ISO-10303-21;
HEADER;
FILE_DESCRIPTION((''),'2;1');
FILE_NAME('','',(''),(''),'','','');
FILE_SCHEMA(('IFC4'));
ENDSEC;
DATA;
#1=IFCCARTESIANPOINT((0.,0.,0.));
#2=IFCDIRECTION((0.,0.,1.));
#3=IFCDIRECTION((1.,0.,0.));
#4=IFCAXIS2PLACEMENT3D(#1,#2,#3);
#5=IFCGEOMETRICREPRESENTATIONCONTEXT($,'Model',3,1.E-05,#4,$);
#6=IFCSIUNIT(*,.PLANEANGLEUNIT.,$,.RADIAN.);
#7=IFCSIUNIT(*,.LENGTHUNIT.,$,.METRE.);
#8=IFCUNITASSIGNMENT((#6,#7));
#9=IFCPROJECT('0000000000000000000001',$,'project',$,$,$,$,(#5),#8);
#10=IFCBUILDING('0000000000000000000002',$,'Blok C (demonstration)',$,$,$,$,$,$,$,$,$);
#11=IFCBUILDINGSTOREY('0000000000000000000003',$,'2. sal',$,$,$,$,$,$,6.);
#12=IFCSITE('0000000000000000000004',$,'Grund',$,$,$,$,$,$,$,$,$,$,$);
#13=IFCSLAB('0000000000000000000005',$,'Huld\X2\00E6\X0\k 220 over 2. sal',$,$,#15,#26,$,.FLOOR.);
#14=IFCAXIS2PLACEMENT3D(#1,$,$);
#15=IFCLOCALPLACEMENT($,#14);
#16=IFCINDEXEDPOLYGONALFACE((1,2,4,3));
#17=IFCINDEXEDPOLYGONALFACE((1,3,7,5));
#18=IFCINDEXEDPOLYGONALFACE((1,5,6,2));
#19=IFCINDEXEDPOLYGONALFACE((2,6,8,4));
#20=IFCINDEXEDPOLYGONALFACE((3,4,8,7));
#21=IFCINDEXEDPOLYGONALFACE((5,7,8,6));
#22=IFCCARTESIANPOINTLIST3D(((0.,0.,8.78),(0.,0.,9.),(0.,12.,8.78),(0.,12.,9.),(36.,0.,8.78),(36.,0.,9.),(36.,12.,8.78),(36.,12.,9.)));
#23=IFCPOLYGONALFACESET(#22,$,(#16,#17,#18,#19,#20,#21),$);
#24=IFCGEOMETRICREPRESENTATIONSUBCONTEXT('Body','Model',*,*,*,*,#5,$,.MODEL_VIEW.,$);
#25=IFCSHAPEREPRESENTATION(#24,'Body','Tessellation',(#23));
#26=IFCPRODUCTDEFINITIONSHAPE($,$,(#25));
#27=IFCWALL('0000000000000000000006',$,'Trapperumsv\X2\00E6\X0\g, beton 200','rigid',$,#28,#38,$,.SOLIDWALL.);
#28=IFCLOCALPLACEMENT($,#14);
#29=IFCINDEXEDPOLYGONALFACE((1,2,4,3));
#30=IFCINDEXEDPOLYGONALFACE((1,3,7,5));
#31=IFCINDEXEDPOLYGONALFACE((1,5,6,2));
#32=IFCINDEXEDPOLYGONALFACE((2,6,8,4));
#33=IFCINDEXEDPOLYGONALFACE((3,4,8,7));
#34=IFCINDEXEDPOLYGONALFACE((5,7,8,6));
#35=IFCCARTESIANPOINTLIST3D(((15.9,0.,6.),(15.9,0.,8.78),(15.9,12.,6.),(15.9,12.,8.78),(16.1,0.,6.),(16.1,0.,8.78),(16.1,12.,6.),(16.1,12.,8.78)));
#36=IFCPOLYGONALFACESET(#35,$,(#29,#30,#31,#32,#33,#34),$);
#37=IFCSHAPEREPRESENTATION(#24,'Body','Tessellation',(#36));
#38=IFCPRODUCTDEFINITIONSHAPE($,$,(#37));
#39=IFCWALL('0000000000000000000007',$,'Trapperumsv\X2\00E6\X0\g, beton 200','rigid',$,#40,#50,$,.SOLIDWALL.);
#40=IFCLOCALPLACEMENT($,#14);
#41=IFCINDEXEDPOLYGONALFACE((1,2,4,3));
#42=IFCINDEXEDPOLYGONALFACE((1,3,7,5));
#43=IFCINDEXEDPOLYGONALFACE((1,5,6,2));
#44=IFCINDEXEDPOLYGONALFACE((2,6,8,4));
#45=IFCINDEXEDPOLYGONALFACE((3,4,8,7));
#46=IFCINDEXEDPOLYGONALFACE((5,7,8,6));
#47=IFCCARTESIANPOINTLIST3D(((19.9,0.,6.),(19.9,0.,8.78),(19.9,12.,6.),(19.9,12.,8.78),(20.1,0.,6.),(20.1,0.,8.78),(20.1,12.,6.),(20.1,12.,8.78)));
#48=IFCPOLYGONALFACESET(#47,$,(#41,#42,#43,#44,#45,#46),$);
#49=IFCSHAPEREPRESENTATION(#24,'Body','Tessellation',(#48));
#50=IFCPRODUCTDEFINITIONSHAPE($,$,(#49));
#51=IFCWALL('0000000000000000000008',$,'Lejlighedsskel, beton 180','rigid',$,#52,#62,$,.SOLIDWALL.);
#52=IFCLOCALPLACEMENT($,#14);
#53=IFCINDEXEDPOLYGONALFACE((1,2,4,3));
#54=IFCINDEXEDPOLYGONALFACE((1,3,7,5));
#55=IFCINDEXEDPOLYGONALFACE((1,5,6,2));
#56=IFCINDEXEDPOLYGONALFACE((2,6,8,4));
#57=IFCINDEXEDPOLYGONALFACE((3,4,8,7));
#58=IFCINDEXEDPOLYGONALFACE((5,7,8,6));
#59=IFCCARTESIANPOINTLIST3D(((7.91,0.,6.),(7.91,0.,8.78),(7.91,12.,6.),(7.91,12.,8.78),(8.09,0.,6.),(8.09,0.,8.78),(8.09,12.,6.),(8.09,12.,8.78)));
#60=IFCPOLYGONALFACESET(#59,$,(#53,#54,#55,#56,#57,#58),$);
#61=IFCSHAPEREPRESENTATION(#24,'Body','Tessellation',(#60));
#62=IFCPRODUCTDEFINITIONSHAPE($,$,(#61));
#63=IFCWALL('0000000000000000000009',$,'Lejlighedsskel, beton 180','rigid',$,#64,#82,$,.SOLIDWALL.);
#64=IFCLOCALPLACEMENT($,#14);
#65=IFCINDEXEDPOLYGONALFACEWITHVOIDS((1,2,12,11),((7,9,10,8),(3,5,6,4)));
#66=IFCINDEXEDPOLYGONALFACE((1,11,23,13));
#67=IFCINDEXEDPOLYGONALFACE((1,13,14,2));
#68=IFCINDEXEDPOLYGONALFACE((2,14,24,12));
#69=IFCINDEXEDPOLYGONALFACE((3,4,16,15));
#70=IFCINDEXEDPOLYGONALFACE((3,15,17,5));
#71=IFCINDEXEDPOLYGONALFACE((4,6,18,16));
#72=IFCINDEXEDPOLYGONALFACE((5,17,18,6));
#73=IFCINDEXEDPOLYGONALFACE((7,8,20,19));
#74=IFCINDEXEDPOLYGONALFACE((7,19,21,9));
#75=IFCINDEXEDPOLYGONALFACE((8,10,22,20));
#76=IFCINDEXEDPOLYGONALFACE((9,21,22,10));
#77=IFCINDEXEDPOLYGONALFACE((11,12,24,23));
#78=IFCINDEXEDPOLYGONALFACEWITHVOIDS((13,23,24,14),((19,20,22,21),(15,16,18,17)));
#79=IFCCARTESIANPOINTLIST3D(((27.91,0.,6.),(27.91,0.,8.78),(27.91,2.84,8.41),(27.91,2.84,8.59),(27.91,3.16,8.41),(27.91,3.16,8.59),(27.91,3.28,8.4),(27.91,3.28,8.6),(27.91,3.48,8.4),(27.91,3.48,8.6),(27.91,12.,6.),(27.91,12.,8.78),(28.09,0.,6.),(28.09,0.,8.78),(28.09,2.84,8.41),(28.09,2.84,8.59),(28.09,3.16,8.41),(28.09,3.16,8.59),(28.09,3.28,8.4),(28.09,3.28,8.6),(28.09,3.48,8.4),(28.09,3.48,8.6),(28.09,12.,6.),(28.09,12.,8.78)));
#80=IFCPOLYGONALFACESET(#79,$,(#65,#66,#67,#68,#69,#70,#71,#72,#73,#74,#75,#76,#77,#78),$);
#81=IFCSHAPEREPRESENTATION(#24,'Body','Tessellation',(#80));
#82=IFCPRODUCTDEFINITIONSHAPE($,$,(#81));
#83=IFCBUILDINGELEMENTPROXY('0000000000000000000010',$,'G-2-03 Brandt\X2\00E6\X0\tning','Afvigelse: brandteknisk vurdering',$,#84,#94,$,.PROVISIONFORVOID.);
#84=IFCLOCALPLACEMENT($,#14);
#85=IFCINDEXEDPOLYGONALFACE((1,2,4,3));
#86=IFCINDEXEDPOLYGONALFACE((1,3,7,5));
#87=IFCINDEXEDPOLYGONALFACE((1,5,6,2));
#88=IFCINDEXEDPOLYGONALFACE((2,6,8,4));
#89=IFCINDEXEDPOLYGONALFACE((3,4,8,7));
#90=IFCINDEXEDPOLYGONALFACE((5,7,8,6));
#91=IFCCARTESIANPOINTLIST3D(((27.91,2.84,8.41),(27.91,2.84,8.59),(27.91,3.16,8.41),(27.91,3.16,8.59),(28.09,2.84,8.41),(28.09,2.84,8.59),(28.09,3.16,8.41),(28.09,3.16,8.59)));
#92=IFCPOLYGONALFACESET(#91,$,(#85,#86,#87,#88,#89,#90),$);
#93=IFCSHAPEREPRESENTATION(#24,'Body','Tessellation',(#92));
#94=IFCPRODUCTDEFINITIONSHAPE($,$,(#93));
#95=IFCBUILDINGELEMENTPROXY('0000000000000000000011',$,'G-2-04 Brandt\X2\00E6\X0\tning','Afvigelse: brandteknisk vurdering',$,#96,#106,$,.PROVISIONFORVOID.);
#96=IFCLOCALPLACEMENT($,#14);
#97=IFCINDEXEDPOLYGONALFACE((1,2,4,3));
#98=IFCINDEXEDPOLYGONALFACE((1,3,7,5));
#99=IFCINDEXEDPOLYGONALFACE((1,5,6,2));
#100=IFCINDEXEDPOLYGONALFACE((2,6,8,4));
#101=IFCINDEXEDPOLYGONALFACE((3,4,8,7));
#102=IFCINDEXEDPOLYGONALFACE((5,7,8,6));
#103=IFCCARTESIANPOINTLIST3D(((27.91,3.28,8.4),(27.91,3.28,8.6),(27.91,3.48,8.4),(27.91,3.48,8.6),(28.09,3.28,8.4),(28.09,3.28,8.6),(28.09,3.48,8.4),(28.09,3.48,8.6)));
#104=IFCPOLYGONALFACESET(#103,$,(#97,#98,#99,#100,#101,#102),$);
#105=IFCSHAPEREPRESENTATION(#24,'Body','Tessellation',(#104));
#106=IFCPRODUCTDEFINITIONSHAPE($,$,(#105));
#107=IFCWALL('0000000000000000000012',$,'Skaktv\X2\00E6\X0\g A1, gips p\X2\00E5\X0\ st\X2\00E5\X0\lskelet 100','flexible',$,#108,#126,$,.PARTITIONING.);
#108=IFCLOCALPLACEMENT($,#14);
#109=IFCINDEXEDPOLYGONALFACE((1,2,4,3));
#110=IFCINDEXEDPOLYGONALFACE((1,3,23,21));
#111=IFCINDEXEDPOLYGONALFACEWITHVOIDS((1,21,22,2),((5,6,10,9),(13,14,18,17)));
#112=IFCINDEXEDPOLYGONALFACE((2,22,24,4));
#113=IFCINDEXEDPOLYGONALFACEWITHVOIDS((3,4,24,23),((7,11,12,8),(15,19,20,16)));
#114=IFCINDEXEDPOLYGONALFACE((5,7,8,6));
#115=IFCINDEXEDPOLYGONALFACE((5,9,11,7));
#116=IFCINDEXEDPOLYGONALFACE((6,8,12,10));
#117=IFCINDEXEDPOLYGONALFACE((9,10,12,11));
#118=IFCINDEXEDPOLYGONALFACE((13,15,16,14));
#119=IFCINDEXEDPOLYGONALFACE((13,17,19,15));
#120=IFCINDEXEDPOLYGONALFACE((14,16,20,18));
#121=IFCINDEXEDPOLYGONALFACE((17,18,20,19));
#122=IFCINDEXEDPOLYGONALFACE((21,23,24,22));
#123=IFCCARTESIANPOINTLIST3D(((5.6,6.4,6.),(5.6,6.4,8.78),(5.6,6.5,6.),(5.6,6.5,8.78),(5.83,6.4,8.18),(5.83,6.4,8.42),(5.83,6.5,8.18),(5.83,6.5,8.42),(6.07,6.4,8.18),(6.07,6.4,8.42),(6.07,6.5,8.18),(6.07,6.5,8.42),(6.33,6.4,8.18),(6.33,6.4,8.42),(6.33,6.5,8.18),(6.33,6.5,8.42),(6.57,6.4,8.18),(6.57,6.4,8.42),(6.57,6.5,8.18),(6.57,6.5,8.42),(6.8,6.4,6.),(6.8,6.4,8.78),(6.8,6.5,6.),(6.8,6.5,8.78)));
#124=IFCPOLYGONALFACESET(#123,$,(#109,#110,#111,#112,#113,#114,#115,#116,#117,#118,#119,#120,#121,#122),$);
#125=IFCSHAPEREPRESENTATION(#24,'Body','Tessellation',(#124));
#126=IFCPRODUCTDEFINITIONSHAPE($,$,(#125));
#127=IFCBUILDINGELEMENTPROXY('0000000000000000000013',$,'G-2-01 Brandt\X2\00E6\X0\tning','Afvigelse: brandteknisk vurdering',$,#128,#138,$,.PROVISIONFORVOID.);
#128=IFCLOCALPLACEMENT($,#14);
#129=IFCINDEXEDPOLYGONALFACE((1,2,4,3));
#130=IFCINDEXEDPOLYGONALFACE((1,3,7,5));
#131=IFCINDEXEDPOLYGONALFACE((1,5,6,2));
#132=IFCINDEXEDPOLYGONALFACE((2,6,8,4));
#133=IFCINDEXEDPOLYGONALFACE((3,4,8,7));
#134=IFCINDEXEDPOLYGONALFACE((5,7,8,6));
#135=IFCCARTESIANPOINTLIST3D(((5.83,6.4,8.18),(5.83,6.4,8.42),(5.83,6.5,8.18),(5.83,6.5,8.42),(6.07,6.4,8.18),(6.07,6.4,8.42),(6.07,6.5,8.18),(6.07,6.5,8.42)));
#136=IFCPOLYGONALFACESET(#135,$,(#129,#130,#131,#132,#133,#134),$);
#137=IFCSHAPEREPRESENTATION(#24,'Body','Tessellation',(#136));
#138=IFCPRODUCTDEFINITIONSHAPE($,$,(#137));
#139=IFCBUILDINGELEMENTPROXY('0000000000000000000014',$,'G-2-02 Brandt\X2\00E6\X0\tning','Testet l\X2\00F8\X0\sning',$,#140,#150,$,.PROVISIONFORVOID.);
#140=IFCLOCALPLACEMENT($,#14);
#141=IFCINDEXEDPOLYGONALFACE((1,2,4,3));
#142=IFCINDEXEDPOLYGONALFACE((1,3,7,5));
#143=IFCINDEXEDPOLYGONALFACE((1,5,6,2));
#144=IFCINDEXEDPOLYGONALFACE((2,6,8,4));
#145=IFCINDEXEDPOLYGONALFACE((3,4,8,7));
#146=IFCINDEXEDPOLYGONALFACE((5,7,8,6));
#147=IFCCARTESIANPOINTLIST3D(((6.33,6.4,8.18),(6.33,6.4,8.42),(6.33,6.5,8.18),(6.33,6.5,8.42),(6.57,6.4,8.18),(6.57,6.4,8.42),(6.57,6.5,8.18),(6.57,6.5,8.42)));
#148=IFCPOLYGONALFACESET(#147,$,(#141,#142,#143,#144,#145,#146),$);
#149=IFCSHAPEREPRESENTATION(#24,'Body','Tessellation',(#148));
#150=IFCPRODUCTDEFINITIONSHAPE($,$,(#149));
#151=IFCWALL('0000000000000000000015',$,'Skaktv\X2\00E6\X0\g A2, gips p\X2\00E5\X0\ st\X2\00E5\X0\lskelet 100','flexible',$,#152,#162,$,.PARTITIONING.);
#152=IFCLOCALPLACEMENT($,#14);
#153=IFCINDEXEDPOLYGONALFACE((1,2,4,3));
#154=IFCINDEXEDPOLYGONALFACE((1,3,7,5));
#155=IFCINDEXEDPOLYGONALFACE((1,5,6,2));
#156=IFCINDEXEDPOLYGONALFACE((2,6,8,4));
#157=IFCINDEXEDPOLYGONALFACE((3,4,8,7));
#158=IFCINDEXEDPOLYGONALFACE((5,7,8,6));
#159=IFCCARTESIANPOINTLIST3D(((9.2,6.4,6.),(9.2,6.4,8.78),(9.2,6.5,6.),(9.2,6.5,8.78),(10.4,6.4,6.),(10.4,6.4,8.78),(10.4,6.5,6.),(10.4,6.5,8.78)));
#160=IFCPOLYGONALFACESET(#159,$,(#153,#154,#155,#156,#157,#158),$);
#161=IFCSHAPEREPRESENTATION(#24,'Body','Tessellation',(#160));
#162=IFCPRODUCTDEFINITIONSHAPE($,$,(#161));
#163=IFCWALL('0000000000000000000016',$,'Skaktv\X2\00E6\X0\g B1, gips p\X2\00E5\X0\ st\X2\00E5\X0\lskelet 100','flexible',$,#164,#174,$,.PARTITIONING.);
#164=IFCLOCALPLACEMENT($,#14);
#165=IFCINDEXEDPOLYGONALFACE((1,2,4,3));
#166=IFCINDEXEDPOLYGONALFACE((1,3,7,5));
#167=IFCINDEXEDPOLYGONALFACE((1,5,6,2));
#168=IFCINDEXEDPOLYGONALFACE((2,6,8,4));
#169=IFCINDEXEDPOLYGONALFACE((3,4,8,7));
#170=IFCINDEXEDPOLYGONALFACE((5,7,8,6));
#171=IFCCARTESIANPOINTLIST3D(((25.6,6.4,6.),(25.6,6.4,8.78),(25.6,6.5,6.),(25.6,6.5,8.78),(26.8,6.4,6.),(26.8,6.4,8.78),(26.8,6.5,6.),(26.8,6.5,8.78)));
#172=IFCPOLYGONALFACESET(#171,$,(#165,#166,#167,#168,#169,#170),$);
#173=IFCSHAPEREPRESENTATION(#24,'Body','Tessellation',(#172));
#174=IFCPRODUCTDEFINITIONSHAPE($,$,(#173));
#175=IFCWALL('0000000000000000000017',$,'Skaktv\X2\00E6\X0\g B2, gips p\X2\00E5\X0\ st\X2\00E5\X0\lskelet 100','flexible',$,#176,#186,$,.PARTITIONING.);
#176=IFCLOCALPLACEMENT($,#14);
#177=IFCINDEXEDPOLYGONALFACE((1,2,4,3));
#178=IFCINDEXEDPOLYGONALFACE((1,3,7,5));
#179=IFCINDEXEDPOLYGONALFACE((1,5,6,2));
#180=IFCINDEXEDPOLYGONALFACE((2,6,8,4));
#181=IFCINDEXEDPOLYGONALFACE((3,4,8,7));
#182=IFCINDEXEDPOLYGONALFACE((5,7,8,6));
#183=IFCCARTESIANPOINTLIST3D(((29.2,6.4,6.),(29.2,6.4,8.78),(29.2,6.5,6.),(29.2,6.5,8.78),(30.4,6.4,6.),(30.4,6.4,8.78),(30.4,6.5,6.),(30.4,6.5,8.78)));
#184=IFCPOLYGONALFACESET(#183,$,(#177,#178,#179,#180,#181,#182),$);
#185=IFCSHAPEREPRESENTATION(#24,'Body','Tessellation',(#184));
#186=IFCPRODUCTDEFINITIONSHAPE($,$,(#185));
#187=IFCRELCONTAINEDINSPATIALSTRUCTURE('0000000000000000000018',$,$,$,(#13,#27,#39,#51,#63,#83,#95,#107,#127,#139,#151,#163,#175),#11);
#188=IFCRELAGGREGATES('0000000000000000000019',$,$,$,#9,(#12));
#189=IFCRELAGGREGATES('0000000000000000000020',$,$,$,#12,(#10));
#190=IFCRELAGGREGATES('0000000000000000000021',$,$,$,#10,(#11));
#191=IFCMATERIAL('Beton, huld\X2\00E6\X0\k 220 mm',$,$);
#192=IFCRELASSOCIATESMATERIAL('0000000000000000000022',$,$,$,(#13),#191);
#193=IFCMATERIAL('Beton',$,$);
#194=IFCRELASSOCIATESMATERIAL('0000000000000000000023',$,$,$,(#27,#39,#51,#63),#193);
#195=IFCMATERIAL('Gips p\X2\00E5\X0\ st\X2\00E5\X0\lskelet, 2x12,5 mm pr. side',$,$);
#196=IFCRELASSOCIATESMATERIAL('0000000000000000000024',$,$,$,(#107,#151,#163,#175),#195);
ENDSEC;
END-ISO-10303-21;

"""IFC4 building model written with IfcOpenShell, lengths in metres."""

from ifc_helpers import new_model, si_unit, frame, origin_with_axes, place, context, subcontext, project, spatial, polyline, outline, extrude, material, element, fill, save


model = new_model("IFC4")

# Units and contexts
model_context = context("Model", 3, precision=1e-05, world=origin_with_axes())
body_context = subcontext(model_context, "Body", "Model", "MODEL_VIEW")
ifc_project = project(units=[si_unit("PLANEANGLEUNIT", "RADIAN"), si_unit("LENGTHUNIT", "METRE")], contexts=[model_context])

# Site, building, storey
site = spatial("IfcSite", under=ifc_project, Name="Grund")
building = spatial("IfcBuilding", under=site, Name="Blok C (demonstration)")
storey = spatial("IfcBuildingStorey", under=building, Name="2. sal", Elevation=6.0)

# Slab
ifc_material_1 = material(Name="Beton, huldæk 220 mm")
slab_placement = place(None, origin_with_axes())
element("IfcSlab", 1, at=slab_placement, inside=storey, material=ifc_material_1, Name="Huldæk 220 over 2. sal", PredefinedType="FLOOR", context=body_context, shape_type="SweptSolid", body=[
    extrude(outline(polyline([(0.0, 0.0), (36.0, 0.0), (36.0, 12.0), (0.0, 12.0), (0.0, 0.0)])), frame((0.0, 0.0, 8.78)), (0.0, 0.0, 1.0), 0.22),
])

# Walls
ifc_material_2 = material(Name="Beton")
wall_1_placement = place(None, origin_with_axes())
element("IfcWall", 2, at=wall_1_placement, inside=storey, material=ifc_material_2, Name="Trapperumsvæg, beton 200", Description="rigid", PredefinedType="SOLIDWALL", context=body_context, shape_type="SweptSolid", body=[
    extrude(outline(polyline([(15.9, 0.0), (16.1, 0.0), (16.1, 12.0), (15.9, 12.0), (15.9, 0.0)])), frame((0.0, 0.0, 6.0)), (0.0, 0.0, 1.0), 2.78),
])
wall_2_placement = place(None, origin_with_axes())
element("IfcWall", 3, at=wall_2_placement, inside=storey, material=ifc_material_2, Name="Trapperumsvæg, beton 200", Description="rigid", PredefinedType="SOLIDWALL", context=body_context, shape_type="SweptSolid", body=[
    extrude(outline(polyline([(19.9, 0.0), (20.1, 0.0), (20.1, 12.0), (19.9, 12.0), (19.9, 0.0)])), frame((0.0, 0.0, 6.0)), (0.0, 0.0, 1.0), 2.78),
])
wall_3_placement = place(None, origin_with_axes())
element("IfcWall", 4, at=wall_3_placement, inside=storey, material=ifc_material_2, Name="Lejlighedsskel, beton 180", Description="rigid", PredefinedType="SOLIDWALL", context=body_context, shape_type="SweptSolid", body=[
    extrude(outline(polyline([(7.91, 0.0), (8.09, 0.0), (8.09, 12.0), (7.91, 12.0), (7.91, 0.0)])), frame((0.0, 0.0, 6.0)), (0.0, 0.0, 1.0), 2.78),
])

# Walls, openings, building element proxies
wall_4_placement = place(None, origin_with_axes())
wall_4 = element("IfcWall", 5, at=wall_4_placement, inside=storey, material=ifc_material_2, Name="Lejlighedsskel, beton 180", Description="rigid", PredefinedType="SOLIDWALL", context=body_context, shape_type="SweptSolid", body=[
    extrude(outline(polyline([(27.91, 0.0), (28.09, 0.0), (28.09, 12.0), (27.91, 12.0), (27.91, 0.0)])), frame((0.0, 0.0, 6.0)), (0.0, 0.0, 1.0), 2.78),
])
opening_1_placement = place(wall_4_placement, origin_with_axes())
opening_1 = element("IfcOpeningElement", 6, at=opening_1_placement, cuts=wall_4, PredefinedType="OPENING", context=body_context, shape_type="SweptSolid", body=[
    extrude(outline(polyline([(27.88, 2.84), (28.12, 2.84), (28.12, 3.16), (27.88, 3.16), (27.88, 2.84)])), frame((0.0, 0.0, 8.41)), (0.0, 0.0, 1.0), 0.18),
])
opening_2_placement = place(wall_4_placement, origin_with_axes())
opening_2 = element("IfcOpeningElement", 7, at=opening_2_placement, cuts=wall_4, PredefinedType="OPENING", context=body_context, shape_type="SweptSolid", body=[
    extrude(outline(polyline([(27.88, 3.28), (28.12, 3.28), (28.12, 3.48), (27.88, 3.48), (27.88, 3.28)])), frame((0.0, 0.0, 8.4)), (0.0, 0.0, 1.0), 0.2),
])
proxy_1_placement = place(None, origin_with_axes())
proxy_1 = element("IfcBuildingElementProxy", 8, at=proxy_1_placement, inside=storey, Name="G-2-03 Brandtætning", Description="Afvigelse: brandteknisk vurdering", PredefinedType="PROVISIONFORVOID", context=body_context, shape_type="SweptSolid", body=[
    extrude(outline(polyline([(27.91, 2.84), (28.09, 2.84), (28.09, 3.16), (27.91, 3.16), (27.91, 2.84)])), frame((0.0, 0.0, 8.41)), (0.0, 0.0, 1.0), 0.18),
])
fill(opening_1, proxy_1)
proxy_2_placement = place(None, origin_with_axes())
proxy_2 = element("IfcBuildingElementProxy", 9, at=proxy_2_placement, inside=storey, Name="G-2-04 Brandtætning", Description="Afvigelse: brandteknisk vurdering", PredefinedType="PROVISIONFORVOID", context=body_context, shape_type="SweptSolid", body=[
    extrude(outline(polyline([(27.91, 3.28), (28.09, 3.28), (28.09, 3.48), (27.91, 3.48), (27.91, 3.28)])), frame((0.0, 0.0, 8.4)), (0.0, 0.0, 1.0), 0.2),
])
fill(opening_2, proxy_2)
ifc_material_3 = material(Name="Gips på stålskelet, 2x12,5 mm pr. side")
wall_5_placement = place(None, origin_with_axes())
wall_5 = element("IfcWall", 10, at=wall_5_placement, inside=storey, material=ifc_material_3, Name="Skaktvæg A1, gips på stålskelet 100", Description="flexible", PredefinedType="PARTITIONING", context=body_context, shape_type="SweptSolid", body=[
    extrude(outline(polyline([(5.6, 6.4), (6.8, 6.4), (6.8, 6.5), (5.6, 6.5), (5.6, 6.4)])), frame((0.0, 0.0, 6.0)), (0.0, 0.0, 1.0), 2.78),
])
opening_3_placement = place(wall_5_placement, origin_with_axes())
opening_3 = element("IfcOpeningElement", 11, at=opening_3_placement, cuts=wall_5, PredefinedType="OPENING", context=body_context, shape_type="SweptSolid", body=[
    extrude(outline(polyline([(5.83, 6.33), (6.07, 6.33), (6.07, 6.57), (5.83, 6.57), (5.83, 6.33)])), frame((0.0, 0.0, 8.18)), (0.0, 0.0, 1.0), 0.24),
])
opening_4_placement = place(wall_5_placement, origin_with_axes())
opening_4 = element("IfcOpeningElement", 12, at=opening_4_placement, cuts=wall_5, PredefinedType="OPENING", context=body_context, shape_type="SweptSolid", body=[
    extrude(outline(polyline([(6.33, 6.33), (6.57, 6.33), (6.57, 6.57), (6.33, 6.57), (6.33, 6.33)])), frame((0.0, 0.0, 8.18)), (0.0, 0.0, 1.0), 0.24),
])
proxy_3_placement = place(None, origin_with_axes())
proxy_3 = element("IfcBuildingElementProxy", 13, at=proxy_3_placement, inside=storey, Name="G-2-01 Brandtætning", Description="Afvigelse: brandteknisk vurdering", PredefinedType="PROVISIONFORVOID", context=body_context, shape_type="SweptSolid", body=[
    extrude(outline(polyline([(5.83, 6.4), (6.07, 6.4), (6.07, 6.5), (5.83, 6.5), (5.83, 6.4)])), frame((0.0, 0.0, 8.18)), (0.0, 0.0, 1.0), 0.24),
])
fill(opening_3, proxy_3)
proxy_4_placement = place(None, origin_with_axes())
proxy_4 = element("IfcBuildingElementProxy", 14, at=proxy_4_placement, inside=storey, Name="G-2-02 Brandtætning", Description="Testet løsning", PredefinedType="PROVISIONFORVOID", context=body_context, shape_type="SweptSolid", body=[
    extrude(outline(polyline([(6.33, 6.4), (6.57, 6.4), (6.57, 6.5), (6.33, 6.5), (6.33, 6.4)])), frame((0.0, 0.0, 8.18)), (0.0, 0.0, 1.0), 0.24),
])
fill(opening_4, proxy_4)

# Walls
wall_6_placement = place(None, origin_with_axes())
element("IfcWall", 15, at=wall_6_placement, inside=storey, material=ifc_material_3, Name="Skaktvæg A2, gips på stålskelet 100", Description="flexible", PredefinedType="PARTITIONING", context=body_context, shape_type="SweptSolid", body=[
    extrude(outline(polyline([(9.2, 6.4), (10.4, 6.4), (10.4, 6.5), (9.2, 6.5), (9.2, 6.4)])), frame((0.0, 0.0, 6.0)), (0.0, 0.0, 1.0), 2.78),
])
wall_7_placement = place(None, origin_with_axes())
element("IfcWall", 16, at=wall_7_placement, inside=storey, material=ifc_material_3, Name="Skaktvæg B1, gips på stålskelet 100", Description="flexible", PredefinedType="PARTITIONING", context=body_context, shape_type="SweptSolid", body=[
    extrude(outline(polyline([(25.6, 6.4), (26.8, 6.4), (26.8, 6.5), (25.6, 6.5), (25.6, 6.4)])), frame((0.0, 0.0, 6.0)), (0.0, 0.0, 1.0), 2.78),
])
wall_8_placement = place(None, origin_with_axes())
element("IfcWall", 17, at=wall_8_placement, inside=storey, material=ifc_material_3, Name="Skaktvæg B2, gips på stålskelet 100", Description="flexible", PredefinedType="PARTITIONING", context=body_context, shape_type="SweptSolid", body=[
    extrude(outline(polyline([(29.2, 6.4), (30.4, 6.4), (30.4, 6.5), (29.2, 6.5), (29.2, 6.4)])), frame((0.0, 0.0, 6.0)), (0.0, 0.0, 1.0), 2.78),
])

save(model, "model.ifc")
